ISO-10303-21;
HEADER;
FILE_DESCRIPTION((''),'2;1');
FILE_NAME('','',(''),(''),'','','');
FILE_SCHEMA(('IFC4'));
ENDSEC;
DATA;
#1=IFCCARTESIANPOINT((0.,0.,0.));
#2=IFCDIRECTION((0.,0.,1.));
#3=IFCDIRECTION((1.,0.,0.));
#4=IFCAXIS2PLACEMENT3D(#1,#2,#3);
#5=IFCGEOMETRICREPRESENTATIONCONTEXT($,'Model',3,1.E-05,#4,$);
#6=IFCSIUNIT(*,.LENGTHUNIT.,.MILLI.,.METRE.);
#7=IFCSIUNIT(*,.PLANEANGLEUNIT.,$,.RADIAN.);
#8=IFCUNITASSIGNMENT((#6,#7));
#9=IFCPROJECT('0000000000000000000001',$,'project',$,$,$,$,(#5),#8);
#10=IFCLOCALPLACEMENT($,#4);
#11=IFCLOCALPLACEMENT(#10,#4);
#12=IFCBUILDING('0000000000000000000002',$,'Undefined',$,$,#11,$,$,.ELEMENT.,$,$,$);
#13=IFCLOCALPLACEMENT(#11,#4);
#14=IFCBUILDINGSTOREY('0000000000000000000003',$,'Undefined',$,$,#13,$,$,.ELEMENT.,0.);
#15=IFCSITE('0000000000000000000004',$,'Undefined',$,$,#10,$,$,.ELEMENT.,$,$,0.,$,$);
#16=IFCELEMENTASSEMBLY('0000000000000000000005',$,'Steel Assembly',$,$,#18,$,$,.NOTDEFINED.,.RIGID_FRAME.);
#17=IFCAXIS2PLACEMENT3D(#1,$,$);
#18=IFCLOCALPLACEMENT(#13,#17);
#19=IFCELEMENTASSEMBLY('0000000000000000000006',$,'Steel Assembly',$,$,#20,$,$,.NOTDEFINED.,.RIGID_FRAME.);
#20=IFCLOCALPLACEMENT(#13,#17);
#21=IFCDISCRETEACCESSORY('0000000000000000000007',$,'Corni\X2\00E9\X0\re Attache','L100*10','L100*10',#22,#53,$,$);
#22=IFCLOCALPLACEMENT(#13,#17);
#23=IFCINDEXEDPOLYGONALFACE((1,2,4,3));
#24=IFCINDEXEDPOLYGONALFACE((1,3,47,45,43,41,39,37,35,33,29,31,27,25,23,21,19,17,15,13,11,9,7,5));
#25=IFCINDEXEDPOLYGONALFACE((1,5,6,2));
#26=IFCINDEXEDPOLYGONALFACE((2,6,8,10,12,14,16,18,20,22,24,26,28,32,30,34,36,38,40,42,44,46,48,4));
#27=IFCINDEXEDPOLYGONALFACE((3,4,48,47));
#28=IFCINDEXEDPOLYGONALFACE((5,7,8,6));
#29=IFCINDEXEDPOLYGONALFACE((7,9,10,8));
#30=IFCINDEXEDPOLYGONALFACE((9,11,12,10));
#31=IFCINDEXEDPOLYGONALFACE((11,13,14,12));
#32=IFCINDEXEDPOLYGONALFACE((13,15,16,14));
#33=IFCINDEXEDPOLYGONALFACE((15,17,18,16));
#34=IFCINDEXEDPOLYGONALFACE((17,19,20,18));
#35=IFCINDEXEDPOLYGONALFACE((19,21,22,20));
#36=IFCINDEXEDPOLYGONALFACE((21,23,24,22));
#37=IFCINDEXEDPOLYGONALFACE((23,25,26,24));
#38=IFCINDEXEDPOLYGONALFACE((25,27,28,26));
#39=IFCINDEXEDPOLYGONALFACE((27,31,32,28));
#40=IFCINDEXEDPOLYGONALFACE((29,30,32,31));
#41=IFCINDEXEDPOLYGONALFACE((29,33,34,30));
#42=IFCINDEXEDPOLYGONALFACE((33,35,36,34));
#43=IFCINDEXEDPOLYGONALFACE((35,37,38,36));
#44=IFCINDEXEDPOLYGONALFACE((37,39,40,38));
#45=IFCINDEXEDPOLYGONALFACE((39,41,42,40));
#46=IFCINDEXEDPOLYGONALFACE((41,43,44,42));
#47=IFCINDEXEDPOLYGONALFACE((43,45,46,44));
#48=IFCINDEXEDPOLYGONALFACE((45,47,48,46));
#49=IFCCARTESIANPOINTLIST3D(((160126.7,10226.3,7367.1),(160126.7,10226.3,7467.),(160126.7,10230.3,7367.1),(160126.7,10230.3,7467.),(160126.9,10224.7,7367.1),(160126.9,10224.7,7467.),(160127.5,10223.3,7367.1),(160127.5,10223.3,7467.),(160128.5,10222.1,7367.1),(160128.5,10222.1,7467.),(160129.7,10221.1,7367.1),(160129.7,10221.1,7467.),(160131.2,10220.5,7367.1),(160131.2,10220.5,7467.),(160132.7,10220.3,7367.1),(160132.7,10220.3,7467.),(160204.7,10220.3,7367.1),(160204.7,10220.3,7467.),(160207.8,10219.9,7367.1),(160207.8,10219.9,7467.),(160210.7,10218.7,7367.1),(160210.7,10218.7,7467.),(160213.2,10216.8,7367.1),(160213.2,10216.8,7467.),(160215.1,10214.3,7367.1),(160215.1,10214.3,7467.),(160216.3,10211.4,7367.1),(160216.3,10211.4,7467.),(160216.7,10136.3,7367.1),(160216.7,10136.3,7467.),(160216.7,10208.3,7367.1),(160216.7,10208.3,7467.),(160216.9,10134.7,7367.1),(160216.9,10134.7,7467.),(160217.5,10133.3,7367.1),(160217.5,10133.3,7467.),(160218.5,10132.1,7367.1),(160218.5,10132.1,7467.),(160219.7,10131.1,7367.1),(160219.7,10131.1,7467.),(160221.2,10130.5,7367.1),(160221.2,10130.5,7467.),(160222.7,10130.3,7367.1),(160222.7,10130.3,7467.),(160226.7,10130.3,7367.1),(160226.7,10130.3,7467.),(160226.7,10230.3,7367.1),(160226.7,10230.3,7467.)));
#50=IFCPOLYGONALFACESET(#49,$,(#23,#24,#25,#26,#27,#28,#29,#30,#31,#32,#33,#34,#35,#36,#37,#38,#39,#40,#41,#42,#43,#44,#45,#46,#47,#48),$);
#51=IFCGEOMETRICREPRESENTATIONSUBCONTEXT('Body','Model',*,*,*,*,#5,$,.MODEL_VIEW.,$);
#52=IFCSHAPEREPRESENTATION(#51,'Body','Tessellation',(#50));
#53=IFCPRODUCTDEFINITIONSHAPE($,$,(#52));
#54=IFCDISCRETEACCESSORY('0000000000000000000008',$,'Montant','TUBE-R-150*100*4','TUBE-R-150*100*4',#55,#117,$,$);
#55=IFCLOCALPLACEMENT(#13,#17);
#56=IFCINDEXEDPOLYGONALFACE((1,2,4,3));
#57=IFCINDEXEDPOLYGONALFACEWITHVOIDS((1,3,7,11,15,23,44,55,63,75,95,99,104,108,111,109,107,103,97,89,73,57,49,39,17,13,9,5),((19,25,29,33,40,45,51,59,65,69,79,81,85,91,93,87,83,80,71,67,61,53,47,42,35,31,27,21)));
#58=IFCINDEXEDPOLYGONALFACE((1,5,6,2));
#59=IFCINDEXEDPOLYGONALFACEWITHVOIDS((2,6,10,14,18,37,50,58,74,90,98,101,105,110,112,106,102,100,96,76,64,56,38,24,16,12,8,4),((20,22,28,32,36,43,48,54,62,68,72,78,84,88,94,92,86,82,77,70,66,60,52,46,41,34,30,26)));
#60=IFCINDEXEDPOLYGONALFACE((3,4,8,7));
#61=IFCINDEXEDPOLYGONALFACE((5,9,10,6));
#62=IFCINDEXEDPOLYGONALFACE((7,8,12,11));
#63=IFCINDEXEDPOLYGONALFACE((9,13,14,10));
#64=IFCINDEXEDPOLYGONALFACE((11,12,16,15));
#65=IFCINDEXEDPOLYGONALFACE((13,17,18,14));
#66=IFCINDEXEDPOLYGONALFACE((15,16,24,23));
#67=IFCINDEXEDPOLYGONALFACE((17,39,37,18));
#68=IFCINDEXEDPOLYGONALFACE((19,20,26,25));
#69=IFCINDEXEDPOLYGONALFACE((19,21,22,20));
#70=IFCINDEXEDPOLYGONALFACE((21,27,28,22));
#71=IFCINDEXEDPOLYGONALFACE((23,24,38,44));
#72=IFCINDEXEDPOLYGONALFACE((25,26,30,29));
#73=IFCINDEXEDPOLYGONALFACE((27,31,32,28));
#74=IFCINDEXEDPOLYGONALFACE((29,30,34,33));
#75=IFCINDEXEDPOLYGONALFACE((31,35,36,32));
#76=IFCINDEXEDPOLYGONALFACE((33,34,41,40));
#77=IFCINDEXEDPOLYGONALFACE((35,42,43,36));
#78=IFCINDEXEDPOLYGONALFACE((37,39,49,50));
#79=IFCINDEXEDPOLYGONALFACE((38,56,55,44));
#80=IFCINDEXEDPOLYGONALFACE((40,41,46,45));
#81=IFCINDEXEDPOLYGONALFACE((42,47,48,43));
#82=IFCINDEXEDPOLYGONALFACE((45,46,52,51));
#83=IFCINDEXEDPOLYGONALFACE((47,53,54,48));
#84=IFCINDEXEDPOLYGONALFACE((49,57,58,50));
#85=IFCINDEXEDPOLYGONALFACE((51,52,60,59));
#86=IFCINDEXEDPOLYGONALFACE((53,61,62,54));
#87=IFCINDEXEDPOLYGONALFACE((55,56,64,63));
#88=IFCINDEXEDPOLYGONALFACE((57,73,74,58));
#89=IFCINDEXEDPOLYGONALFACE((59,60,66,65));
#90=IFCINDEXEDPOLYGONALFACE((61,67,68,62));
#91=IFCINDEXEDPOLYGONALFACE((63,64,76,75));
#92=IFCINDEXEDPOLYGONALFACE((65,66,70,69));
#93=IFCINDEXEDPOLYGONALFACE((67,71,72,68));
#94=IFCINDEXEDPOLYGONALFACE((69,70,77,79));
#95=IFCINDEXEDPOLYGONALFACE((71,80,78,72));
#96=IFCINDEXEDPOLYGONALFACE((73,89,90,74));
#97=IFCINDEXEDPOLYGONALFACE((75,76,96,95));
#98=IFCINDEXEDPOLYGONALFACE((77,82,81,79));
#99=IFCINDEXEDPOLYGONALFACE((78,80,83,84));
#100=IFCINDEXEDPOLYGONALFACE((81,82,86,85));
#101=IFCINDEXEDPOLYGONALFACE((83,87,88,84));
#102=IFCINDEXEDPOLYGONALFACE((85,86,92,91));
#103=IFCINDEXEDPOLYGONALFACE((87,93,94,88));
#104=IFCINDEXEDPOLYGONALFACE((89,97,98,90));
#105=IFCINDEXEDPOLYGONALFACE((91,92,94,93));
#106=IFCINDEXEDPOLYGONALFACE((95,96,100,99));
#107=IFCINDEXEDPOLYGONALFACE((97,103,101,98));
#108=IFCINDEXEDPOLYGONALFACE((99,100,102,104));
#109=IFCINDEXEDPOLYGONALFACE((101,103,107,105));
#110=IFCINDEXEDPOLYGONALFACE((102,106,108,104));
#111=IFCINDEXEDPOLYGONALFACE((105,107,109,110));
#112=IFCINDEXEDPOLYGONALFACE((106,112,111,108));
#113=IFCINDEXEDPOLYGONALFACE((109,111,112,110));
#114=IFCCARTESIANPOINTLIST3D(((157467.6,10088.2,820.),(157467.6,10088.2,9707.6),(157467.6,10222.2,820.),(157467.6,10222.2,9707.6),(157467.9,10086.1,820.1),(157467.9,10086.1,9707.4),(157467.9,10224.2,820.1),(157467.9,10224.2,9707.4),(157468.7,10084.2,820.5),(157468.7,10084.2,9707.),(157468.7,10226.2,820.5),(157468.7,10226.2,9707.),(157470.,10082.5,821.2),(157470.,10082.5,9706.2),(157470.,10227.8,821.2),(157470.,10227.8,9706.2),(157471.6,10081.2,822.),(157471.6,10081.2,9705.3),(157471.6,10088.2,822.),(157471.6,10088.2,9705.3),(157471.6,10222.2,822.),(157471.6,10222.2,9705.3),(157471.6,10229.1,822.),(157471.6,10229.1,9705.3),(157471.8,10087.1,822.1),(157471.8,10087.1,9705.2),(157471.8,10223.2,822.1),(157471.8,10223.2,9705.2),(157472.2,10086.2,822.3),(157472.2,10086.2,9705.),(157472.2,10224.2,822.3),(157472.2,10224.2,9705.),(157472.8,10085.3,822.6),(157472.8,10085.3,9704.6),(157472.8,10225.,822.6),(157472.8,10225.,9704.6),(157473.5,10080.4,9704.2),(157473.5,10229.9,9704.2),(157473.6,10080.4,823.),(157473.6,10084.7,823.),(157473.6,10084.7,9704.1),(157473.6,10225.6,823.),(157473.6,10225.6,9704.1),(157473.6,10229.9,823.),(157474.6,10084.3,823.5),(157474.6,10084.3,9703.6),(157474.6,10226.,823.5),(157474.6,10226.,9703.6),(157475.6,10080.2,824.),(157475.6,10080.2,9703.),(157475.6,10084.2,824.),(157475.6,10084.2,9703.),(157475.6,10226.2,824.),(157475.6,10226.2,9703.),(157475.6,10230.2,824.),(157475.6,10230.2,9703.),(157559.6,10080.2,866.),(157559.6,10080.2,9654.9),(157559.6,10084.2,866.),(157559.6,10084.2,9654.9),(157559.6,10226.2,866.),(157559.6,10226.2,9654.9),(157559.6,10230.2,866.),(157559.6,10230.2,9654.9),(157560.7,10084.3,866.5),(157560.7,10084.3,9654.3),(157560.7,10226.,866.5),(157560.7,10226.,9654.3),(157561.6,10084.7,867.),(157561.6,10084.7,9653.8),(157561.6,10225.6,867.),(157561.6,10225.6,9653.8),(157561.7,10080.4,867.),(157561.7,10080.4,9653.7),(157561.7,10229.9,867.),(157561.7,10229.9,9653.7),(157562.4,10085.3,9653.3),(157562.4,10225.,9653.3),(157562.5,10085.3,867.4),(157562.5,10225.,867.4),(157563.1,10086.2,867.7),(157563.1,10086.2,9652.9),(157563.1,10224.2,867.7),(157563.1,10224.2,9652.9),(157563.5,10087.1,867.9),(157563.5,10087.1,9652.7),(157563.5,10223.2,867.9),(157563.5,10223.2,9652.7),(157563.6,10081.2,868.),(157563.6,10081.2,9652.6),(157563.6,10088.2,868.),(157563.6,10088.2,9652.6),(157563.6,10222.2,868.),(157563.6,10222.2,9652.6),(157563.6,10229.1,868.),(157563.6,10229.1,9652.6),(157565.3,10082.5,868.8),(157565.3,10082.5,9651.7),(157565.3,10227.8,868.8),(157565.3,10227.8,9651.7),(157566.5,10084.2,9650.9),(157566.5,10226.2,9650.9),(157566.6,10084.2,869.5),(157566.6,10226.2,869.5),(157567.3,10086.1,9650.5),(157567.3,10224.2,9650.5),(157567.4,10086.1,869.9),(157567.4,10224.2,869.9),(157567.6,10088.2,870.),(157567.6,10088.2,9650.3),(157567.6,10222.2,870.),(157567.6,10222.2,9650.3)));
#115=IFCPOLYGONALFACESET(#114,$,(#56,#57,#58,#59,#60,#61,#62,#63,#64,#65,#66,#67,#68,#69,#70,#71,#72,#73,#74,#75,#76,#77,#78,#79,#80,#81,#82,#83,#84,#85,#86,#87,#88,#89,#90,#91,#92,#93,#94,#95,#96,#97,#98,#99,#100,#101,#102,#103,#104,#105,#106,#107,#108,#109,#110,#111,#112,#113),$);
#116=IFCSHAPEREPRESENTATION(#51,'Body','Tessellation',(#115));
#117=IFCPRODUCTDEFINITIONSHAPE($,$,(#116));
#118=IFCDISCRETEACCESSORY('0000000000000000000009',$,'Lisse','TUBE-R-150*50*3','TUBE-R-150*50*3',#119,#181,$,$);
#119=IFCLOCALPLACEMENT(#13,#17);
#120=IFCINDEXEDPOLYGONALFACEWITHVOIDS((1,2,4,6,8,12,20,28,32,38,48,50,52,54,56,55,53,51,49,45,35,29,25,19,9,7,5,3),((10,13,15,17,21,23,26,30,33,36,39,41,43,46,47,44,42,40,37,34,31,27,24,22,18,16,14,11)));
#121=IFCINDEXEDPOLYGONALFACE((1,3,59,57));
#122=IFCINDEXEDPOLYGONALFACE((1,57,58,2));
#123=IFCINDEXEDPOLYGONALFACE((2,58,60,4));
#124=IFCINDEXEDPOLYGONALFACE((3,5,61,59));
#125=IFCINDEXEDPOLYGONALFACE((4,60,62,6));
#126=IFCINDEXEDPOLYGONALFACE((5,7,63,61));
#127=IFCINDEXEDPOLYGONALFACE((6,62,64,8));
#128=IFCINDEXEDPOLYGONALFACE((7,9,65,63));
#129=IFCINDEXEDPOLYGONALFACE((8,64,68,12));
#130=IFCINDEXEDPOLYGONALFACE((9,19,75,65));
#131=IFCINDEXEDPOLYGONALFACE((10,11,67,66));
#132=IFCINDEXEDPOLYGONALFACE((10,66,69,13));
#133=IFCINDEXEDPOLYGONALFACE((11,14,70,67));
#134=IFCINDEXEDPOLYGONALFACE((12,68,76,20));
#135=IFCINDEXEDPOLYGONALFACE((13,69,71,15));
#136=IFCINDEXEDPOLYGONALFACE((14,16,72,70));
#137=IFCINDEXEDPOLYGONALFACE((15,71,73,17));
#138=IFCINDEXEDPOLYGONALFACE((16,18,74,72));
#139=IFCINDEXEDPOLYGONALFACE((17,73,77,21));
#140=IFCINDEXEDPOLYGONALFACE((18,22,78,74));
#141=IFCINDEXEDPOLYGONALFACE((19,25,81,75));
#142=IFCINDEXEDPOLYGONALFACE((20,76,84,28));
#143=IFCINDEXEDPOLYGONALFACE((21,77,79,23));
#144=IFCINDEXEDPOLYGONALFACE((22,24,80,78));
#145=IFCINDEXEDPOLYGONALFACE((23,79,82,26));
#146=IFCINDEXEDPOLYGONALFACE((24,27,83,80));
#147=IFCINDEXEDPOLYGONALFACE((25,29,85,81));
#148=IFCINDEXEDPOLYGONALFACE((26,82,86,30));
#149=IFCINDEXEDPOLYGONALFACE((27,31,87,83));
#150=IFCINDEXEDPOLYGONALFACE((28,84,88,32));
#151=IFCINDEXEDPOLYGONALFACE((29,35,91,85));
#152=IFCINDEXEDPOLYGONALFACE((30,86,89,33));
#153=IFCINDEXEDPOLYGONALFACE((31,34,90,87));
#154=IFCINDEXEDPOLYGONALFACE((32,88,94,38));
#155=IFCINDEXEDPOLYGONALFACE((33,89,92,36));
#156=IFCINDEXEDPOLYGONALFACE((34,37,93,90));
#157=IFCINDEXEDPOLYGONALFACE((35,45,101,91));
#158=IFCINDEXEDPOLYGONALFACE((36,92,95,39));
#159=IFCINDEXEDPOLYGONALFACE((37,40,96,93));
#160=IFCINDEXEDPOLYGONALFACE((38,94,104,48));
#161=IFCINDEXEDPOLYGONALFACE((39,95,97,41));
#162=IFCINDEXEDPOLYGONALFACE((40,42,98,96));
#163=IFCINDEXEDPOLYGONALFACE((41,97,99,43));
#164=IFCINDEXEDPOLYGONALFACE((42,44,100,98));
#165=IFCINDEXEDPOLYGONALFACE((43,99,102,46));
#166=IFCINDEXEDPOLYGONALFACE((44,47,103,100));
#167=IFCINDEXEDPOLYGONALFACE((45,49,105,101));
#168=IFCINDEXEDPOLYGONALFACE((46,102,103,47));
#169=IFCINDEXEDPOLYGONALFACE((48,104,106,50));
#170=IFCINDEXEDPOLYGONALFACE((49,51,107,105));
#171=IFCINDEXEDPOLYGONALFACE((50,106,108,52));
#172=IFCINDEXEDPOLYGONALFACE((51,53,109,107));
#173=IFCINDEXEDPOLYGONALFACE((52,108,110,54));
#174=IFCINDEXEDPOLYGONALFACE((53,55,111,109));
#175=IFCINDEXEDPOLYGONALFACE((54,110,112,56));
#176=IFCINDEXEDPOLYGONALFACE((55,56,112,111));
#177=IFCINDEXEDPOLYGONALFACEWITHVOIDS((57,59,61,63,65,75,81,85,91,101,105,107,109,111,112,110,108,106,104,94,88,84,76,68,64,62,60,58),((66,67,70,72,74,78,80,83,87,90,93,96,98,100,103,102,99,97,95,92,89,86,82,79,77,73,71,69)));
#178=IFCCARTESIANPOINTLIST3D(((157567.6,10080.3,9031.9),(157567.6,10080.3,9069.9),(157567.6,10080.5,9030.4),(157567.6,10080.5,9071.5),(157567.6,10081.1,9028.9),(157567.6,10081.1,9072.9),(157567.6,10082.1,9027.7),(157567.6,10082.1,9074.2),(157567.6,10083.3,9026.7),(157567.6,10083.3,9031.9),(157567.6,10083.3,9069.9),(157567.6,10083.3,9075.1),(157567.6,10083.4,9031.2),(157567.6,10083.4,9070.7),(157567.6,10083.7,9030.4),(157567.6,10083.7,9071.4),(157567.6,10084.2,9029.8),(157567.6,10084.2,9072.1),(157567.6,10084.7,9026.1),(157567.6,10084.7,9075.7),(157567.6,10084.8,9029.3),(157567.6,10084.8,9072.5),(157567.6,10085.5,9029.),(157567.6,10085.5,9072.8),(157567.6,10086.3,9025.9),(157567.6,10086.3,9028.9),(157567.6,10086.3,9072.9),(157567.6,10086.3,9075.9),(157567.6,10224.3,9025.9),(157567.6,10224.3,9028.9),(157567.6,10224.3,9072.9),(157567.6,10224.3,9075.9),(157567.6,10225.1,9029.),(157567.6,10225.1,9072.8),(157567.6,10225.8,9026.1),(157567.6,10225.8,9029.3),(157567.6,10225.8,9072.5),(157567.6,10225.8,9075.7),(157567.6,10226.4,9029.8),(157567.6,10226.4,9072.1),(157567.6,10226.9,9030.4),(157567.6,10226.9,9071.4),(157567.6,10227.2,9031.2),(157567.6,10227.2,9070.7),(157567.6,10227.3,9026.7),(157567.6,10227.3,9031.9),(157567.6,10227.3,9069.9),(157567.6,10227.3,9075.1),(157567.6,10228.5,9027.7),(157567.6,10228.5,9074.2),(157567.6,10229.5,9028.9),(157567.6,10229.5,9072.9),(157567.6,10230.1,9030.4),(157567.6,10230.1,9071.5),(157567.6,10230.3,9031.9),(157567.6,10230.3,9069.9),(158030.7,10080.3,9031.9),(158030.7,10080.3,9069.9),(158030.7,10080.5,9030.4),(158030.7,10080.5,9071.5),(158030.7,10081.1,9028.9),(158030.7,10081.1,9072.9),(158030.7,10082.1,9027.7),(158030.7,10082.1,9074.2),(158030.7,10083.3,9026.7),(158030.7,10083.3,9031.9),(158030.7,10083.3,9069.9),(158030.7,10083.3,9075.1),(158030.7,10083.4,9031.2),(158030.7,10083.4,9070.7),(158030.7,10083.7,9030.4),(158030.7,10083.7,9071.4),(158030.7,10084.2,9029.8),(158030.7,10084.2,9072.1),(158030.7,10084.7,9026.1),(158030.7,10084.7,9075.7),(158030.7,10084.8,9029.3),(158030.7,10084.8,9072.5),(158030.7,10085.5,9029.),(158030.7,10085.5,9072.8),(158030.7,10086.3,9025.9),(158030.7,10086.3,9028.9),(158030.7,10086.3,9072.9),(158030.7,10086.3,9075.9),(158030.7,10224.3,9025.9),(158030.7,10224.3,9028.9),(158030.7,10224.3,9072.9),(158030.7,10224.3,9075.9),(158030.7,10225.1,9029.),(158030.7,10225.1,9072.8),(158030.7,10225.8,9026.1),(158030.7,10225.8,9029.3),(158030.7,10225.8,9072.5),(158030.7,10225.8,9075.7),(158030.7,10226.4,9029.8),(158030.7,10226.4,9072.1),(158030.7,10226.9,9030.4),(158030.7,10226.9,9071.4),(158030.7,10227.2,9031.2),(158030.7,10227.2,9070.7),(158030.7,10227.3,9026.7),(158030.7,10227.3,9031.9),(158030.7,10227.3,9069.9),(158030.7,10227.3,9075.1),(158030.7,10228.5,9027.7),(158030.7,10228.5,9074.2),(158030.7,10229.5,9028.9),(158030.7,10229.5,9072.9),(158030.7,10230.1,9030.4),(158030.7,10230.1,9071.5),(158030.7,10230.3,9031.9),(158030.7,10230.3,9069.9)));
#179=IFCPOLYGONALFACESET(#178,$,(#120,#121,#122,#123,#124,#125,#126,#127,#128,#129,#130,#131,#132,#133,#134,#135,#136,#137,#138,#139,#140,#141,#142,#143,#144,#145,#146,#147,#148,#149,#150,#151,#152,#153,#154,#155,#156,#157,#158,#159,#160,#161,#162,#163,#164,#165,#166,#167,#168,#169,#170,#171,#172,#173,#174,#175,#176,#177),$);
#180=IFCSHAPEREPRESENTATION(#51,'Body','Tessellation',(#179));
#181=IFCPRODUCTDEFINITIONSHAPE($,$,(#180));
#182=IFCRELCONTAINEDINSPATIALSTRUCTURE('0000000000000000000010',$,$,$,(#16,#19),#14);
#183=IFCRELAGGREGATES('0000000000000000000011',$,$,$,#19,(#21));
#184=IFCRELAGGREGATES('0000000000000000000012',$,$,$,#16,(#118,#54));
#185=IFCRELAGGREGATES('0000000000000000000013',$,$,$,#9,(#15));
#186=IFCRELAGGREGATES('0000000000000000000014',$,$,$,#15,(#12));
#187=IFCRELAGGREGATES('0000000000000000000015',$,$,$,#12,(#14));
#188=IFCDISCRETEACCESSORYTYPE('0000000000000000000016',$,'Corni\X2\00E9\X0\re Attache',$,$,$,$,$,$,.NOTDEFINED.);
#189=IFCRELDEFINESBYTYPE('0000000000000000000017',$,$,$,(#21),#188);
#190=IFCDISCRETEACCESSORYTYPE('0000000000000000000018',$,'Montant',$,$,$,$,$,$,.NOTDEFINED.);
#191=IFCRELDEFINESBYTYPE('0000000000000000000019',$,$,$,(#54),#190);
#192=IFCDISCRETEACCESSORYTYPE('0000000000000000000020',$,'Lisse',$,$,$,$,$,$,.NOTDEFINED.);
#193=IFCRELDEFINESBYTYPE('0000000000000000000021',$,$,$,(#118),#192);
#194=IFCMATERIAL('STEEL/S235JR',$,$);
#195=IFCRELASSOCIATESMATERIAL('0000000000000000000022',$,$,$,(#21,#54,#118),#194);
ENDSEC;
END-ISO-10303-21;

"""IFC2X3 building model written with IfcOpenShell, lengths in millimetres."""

from ifc_helpers import new_model, si_unit, frame, origin_with_axes, origin_2d_with_axis, place, context, subcontext, project, spatial, hollow_rectangle, l_section, extrude, clip, halfspace, material, type_object, element, aggregate, save


model = new_model("IFC2X3")

# Units and contexts
model_context = context("Model", 3, precision=1e-05, world=origin_with_axes())
body_context = subcontext(model_context, "Body", "Model", "MODEL_VIEW")
ifc_project = project(units=[si_unit("LENGTHUNIT", "METRE", prefix="MILLI"), si_unit("PLANEANGLEUNIT", "RADIAN")], contexts=[model_context])

# Site, building, storey
site_placement = place(None, origin_with_axes())
site = spatial("IfcSite", under=ifc_project, at=site_placement, Name="Undefined", CompositionType="ELEMENT", RefElevation=0.0)
building_placement = place(site_placement, origin_with_axes())
building = spatial("IfcBuilding", under=site, at=building_placement, Name="Undefined", CompositionType="ELEMENT")
storey_placement = place(building_placement, origin_with_axes())
storey = spatial("IfcBuildingStorey", under=building, at=storey_placement, Name="Undefined", CompositionType="ELEMENT", Elevation=0.0)

# Element assembly
assembly_1_placement = place(storey_placement, origin_with_axes())
assembly_1 = element("IfcElementAssembly", 1, at=assembly_1_placement, inside=storey, Name="Steel Assembly", AssemblyPlace="NOTDEFINED", PredefinedType="RIGID_FRAME")
ifc_material_1 = material(Name="STEEL/S235JR")

# Element assembly
assembly_2_placement = place(storey_placement, origin_with_axes())
assembly_2 = element("IfcElementAssembly", 2, at=assembly_2_placement, inside=storey, Name="Steel Assembly", AssemblyPlace="NOTDEFINED", PredefinedType="RIGID_FRAME")

# Discrete accessories
discrete_accessory_type_1 = type_object("IfcDiscreteAccessoryType", Name="Corniére Attache")
discrete_accessory_1_placement = place(assembly_2_placement, frame((160176.7, 10180.3, 7467.0), z_axis=(0.0, -1.0, 0.0), x_axis=(0.0, 0.0, -1.0)))
discrete_accessory_1 = element("IfcDiscreteAccessory", 3, at=discrete_accessory_1_placement, type_object=discrete_accessory_type_1, material=ifc_material_1, Name="Corniére Attache", Description="L100*10", ObjectType="L100*10", context=body_context, shape_type="SweptSolid", body=[
    extrude(l_section(Depth=100.0, Width=100.0, Thickness=10.0, FilletRadius=12.0, EdgeRadius=6.0, at=origin_2d_with_axis()), frame((99.9, 0.0, 0.0), z_axis=(-1.0, 0.0, 0.0), x_axis=(0.0, -1.0, 0.0)), (0.0, 0.0, 1.0), 99.9),
])
aggregate(assembly_2, [discrete_accessory_1])
discrete_accessory_type_2 = type_object("IfcDiscreteAccessoryType", Name="Montant")
discrete_accessory_2_placement = place(assembly_1_placement, frame((157517.6, 10155.2, 9706.3), z_axis=(0.0, 1.0, 0.0), x_axis=(0.000001, 0.0, -1.0)))
discrete_accessory_2 = element("IfcDiscreteAccessory", 4, at=discrete_accessory_2_placement, type_object=discrete_accessory_type_2, material=ifc_material_1, Name="Montant", Description="TUBE-R-150*100*4", ObjectType="TUBE-R-150*100*4", context=body_context, shape_type="Clipping", body=[
    clip(clip(extrude(hollow_rectangle(XDim=100.0, YDim=150.0, WallThickness=4.0, InnerFilletRadius=4.0, OuterFilletRadius=8.0, at=origin_2d_with_axis()), frame((8915.5, 0.0, 0.0), z_axis=(-1.0, 0.0, 0.0), x_axis=(0.0, -1.0, 0.0)), (0.0, 0.0, 1.0), 8974.5), halfspace(frame((8881.0, 39.5, 0.1), z_axis=(0.894437, -0.447193, 0.0), x_axis=(0.0, 0.0, -1.0)), False)), halfspace(frame((56.0, -50.0, 0.1), z_axis=(-0.867843, -0.496839, 0.0), x_axis=(0.0, 0.0, -1.0)), False)),
])
discrete_accessory_type_3 = type_object("IfcDiscreteAccessoryType", Name="Lisse")

# Discrete accessory
discrete_accessory_3_placement = place(assembly_1_placement, frame((158030.7, 10155.3, 9050.9), z_axis=(0.0, 1.0, 0.0), x_axis=(-1.0, 0.0, 0.0)))
discrete_accessory_3 = element("IfcDiscreteAccessory", 5, at=discrete_accessory_3_placement, type_object=discrete_accessory_type_3, material=ifc_material_1, Name="Lisse", Description="TUBE-R-150*50*3", ObjectType="TUBE-R-150*50*3", context=body_context, shape_type="SweptSolid", body=[
    extrude(hollow_rectangle(XDim=50.0, YDim=150.0, WallThickness=3.0, InnerFilletRadius=3.0, OuterFilletRadius=6.0, at=origin_2d_with_axis()), frame((463.1, 0.0, 0.0), z_axis=(-1.0, 0.0, 0.0), x_axis=(0.0, -1.0, 0.0)), (0.0, 0.0, 1.0), 463.1),
])
aggregate(assembly_1, [discrete_accessory_3, discrete_accessory_2])

save(model, "model.ifc")
